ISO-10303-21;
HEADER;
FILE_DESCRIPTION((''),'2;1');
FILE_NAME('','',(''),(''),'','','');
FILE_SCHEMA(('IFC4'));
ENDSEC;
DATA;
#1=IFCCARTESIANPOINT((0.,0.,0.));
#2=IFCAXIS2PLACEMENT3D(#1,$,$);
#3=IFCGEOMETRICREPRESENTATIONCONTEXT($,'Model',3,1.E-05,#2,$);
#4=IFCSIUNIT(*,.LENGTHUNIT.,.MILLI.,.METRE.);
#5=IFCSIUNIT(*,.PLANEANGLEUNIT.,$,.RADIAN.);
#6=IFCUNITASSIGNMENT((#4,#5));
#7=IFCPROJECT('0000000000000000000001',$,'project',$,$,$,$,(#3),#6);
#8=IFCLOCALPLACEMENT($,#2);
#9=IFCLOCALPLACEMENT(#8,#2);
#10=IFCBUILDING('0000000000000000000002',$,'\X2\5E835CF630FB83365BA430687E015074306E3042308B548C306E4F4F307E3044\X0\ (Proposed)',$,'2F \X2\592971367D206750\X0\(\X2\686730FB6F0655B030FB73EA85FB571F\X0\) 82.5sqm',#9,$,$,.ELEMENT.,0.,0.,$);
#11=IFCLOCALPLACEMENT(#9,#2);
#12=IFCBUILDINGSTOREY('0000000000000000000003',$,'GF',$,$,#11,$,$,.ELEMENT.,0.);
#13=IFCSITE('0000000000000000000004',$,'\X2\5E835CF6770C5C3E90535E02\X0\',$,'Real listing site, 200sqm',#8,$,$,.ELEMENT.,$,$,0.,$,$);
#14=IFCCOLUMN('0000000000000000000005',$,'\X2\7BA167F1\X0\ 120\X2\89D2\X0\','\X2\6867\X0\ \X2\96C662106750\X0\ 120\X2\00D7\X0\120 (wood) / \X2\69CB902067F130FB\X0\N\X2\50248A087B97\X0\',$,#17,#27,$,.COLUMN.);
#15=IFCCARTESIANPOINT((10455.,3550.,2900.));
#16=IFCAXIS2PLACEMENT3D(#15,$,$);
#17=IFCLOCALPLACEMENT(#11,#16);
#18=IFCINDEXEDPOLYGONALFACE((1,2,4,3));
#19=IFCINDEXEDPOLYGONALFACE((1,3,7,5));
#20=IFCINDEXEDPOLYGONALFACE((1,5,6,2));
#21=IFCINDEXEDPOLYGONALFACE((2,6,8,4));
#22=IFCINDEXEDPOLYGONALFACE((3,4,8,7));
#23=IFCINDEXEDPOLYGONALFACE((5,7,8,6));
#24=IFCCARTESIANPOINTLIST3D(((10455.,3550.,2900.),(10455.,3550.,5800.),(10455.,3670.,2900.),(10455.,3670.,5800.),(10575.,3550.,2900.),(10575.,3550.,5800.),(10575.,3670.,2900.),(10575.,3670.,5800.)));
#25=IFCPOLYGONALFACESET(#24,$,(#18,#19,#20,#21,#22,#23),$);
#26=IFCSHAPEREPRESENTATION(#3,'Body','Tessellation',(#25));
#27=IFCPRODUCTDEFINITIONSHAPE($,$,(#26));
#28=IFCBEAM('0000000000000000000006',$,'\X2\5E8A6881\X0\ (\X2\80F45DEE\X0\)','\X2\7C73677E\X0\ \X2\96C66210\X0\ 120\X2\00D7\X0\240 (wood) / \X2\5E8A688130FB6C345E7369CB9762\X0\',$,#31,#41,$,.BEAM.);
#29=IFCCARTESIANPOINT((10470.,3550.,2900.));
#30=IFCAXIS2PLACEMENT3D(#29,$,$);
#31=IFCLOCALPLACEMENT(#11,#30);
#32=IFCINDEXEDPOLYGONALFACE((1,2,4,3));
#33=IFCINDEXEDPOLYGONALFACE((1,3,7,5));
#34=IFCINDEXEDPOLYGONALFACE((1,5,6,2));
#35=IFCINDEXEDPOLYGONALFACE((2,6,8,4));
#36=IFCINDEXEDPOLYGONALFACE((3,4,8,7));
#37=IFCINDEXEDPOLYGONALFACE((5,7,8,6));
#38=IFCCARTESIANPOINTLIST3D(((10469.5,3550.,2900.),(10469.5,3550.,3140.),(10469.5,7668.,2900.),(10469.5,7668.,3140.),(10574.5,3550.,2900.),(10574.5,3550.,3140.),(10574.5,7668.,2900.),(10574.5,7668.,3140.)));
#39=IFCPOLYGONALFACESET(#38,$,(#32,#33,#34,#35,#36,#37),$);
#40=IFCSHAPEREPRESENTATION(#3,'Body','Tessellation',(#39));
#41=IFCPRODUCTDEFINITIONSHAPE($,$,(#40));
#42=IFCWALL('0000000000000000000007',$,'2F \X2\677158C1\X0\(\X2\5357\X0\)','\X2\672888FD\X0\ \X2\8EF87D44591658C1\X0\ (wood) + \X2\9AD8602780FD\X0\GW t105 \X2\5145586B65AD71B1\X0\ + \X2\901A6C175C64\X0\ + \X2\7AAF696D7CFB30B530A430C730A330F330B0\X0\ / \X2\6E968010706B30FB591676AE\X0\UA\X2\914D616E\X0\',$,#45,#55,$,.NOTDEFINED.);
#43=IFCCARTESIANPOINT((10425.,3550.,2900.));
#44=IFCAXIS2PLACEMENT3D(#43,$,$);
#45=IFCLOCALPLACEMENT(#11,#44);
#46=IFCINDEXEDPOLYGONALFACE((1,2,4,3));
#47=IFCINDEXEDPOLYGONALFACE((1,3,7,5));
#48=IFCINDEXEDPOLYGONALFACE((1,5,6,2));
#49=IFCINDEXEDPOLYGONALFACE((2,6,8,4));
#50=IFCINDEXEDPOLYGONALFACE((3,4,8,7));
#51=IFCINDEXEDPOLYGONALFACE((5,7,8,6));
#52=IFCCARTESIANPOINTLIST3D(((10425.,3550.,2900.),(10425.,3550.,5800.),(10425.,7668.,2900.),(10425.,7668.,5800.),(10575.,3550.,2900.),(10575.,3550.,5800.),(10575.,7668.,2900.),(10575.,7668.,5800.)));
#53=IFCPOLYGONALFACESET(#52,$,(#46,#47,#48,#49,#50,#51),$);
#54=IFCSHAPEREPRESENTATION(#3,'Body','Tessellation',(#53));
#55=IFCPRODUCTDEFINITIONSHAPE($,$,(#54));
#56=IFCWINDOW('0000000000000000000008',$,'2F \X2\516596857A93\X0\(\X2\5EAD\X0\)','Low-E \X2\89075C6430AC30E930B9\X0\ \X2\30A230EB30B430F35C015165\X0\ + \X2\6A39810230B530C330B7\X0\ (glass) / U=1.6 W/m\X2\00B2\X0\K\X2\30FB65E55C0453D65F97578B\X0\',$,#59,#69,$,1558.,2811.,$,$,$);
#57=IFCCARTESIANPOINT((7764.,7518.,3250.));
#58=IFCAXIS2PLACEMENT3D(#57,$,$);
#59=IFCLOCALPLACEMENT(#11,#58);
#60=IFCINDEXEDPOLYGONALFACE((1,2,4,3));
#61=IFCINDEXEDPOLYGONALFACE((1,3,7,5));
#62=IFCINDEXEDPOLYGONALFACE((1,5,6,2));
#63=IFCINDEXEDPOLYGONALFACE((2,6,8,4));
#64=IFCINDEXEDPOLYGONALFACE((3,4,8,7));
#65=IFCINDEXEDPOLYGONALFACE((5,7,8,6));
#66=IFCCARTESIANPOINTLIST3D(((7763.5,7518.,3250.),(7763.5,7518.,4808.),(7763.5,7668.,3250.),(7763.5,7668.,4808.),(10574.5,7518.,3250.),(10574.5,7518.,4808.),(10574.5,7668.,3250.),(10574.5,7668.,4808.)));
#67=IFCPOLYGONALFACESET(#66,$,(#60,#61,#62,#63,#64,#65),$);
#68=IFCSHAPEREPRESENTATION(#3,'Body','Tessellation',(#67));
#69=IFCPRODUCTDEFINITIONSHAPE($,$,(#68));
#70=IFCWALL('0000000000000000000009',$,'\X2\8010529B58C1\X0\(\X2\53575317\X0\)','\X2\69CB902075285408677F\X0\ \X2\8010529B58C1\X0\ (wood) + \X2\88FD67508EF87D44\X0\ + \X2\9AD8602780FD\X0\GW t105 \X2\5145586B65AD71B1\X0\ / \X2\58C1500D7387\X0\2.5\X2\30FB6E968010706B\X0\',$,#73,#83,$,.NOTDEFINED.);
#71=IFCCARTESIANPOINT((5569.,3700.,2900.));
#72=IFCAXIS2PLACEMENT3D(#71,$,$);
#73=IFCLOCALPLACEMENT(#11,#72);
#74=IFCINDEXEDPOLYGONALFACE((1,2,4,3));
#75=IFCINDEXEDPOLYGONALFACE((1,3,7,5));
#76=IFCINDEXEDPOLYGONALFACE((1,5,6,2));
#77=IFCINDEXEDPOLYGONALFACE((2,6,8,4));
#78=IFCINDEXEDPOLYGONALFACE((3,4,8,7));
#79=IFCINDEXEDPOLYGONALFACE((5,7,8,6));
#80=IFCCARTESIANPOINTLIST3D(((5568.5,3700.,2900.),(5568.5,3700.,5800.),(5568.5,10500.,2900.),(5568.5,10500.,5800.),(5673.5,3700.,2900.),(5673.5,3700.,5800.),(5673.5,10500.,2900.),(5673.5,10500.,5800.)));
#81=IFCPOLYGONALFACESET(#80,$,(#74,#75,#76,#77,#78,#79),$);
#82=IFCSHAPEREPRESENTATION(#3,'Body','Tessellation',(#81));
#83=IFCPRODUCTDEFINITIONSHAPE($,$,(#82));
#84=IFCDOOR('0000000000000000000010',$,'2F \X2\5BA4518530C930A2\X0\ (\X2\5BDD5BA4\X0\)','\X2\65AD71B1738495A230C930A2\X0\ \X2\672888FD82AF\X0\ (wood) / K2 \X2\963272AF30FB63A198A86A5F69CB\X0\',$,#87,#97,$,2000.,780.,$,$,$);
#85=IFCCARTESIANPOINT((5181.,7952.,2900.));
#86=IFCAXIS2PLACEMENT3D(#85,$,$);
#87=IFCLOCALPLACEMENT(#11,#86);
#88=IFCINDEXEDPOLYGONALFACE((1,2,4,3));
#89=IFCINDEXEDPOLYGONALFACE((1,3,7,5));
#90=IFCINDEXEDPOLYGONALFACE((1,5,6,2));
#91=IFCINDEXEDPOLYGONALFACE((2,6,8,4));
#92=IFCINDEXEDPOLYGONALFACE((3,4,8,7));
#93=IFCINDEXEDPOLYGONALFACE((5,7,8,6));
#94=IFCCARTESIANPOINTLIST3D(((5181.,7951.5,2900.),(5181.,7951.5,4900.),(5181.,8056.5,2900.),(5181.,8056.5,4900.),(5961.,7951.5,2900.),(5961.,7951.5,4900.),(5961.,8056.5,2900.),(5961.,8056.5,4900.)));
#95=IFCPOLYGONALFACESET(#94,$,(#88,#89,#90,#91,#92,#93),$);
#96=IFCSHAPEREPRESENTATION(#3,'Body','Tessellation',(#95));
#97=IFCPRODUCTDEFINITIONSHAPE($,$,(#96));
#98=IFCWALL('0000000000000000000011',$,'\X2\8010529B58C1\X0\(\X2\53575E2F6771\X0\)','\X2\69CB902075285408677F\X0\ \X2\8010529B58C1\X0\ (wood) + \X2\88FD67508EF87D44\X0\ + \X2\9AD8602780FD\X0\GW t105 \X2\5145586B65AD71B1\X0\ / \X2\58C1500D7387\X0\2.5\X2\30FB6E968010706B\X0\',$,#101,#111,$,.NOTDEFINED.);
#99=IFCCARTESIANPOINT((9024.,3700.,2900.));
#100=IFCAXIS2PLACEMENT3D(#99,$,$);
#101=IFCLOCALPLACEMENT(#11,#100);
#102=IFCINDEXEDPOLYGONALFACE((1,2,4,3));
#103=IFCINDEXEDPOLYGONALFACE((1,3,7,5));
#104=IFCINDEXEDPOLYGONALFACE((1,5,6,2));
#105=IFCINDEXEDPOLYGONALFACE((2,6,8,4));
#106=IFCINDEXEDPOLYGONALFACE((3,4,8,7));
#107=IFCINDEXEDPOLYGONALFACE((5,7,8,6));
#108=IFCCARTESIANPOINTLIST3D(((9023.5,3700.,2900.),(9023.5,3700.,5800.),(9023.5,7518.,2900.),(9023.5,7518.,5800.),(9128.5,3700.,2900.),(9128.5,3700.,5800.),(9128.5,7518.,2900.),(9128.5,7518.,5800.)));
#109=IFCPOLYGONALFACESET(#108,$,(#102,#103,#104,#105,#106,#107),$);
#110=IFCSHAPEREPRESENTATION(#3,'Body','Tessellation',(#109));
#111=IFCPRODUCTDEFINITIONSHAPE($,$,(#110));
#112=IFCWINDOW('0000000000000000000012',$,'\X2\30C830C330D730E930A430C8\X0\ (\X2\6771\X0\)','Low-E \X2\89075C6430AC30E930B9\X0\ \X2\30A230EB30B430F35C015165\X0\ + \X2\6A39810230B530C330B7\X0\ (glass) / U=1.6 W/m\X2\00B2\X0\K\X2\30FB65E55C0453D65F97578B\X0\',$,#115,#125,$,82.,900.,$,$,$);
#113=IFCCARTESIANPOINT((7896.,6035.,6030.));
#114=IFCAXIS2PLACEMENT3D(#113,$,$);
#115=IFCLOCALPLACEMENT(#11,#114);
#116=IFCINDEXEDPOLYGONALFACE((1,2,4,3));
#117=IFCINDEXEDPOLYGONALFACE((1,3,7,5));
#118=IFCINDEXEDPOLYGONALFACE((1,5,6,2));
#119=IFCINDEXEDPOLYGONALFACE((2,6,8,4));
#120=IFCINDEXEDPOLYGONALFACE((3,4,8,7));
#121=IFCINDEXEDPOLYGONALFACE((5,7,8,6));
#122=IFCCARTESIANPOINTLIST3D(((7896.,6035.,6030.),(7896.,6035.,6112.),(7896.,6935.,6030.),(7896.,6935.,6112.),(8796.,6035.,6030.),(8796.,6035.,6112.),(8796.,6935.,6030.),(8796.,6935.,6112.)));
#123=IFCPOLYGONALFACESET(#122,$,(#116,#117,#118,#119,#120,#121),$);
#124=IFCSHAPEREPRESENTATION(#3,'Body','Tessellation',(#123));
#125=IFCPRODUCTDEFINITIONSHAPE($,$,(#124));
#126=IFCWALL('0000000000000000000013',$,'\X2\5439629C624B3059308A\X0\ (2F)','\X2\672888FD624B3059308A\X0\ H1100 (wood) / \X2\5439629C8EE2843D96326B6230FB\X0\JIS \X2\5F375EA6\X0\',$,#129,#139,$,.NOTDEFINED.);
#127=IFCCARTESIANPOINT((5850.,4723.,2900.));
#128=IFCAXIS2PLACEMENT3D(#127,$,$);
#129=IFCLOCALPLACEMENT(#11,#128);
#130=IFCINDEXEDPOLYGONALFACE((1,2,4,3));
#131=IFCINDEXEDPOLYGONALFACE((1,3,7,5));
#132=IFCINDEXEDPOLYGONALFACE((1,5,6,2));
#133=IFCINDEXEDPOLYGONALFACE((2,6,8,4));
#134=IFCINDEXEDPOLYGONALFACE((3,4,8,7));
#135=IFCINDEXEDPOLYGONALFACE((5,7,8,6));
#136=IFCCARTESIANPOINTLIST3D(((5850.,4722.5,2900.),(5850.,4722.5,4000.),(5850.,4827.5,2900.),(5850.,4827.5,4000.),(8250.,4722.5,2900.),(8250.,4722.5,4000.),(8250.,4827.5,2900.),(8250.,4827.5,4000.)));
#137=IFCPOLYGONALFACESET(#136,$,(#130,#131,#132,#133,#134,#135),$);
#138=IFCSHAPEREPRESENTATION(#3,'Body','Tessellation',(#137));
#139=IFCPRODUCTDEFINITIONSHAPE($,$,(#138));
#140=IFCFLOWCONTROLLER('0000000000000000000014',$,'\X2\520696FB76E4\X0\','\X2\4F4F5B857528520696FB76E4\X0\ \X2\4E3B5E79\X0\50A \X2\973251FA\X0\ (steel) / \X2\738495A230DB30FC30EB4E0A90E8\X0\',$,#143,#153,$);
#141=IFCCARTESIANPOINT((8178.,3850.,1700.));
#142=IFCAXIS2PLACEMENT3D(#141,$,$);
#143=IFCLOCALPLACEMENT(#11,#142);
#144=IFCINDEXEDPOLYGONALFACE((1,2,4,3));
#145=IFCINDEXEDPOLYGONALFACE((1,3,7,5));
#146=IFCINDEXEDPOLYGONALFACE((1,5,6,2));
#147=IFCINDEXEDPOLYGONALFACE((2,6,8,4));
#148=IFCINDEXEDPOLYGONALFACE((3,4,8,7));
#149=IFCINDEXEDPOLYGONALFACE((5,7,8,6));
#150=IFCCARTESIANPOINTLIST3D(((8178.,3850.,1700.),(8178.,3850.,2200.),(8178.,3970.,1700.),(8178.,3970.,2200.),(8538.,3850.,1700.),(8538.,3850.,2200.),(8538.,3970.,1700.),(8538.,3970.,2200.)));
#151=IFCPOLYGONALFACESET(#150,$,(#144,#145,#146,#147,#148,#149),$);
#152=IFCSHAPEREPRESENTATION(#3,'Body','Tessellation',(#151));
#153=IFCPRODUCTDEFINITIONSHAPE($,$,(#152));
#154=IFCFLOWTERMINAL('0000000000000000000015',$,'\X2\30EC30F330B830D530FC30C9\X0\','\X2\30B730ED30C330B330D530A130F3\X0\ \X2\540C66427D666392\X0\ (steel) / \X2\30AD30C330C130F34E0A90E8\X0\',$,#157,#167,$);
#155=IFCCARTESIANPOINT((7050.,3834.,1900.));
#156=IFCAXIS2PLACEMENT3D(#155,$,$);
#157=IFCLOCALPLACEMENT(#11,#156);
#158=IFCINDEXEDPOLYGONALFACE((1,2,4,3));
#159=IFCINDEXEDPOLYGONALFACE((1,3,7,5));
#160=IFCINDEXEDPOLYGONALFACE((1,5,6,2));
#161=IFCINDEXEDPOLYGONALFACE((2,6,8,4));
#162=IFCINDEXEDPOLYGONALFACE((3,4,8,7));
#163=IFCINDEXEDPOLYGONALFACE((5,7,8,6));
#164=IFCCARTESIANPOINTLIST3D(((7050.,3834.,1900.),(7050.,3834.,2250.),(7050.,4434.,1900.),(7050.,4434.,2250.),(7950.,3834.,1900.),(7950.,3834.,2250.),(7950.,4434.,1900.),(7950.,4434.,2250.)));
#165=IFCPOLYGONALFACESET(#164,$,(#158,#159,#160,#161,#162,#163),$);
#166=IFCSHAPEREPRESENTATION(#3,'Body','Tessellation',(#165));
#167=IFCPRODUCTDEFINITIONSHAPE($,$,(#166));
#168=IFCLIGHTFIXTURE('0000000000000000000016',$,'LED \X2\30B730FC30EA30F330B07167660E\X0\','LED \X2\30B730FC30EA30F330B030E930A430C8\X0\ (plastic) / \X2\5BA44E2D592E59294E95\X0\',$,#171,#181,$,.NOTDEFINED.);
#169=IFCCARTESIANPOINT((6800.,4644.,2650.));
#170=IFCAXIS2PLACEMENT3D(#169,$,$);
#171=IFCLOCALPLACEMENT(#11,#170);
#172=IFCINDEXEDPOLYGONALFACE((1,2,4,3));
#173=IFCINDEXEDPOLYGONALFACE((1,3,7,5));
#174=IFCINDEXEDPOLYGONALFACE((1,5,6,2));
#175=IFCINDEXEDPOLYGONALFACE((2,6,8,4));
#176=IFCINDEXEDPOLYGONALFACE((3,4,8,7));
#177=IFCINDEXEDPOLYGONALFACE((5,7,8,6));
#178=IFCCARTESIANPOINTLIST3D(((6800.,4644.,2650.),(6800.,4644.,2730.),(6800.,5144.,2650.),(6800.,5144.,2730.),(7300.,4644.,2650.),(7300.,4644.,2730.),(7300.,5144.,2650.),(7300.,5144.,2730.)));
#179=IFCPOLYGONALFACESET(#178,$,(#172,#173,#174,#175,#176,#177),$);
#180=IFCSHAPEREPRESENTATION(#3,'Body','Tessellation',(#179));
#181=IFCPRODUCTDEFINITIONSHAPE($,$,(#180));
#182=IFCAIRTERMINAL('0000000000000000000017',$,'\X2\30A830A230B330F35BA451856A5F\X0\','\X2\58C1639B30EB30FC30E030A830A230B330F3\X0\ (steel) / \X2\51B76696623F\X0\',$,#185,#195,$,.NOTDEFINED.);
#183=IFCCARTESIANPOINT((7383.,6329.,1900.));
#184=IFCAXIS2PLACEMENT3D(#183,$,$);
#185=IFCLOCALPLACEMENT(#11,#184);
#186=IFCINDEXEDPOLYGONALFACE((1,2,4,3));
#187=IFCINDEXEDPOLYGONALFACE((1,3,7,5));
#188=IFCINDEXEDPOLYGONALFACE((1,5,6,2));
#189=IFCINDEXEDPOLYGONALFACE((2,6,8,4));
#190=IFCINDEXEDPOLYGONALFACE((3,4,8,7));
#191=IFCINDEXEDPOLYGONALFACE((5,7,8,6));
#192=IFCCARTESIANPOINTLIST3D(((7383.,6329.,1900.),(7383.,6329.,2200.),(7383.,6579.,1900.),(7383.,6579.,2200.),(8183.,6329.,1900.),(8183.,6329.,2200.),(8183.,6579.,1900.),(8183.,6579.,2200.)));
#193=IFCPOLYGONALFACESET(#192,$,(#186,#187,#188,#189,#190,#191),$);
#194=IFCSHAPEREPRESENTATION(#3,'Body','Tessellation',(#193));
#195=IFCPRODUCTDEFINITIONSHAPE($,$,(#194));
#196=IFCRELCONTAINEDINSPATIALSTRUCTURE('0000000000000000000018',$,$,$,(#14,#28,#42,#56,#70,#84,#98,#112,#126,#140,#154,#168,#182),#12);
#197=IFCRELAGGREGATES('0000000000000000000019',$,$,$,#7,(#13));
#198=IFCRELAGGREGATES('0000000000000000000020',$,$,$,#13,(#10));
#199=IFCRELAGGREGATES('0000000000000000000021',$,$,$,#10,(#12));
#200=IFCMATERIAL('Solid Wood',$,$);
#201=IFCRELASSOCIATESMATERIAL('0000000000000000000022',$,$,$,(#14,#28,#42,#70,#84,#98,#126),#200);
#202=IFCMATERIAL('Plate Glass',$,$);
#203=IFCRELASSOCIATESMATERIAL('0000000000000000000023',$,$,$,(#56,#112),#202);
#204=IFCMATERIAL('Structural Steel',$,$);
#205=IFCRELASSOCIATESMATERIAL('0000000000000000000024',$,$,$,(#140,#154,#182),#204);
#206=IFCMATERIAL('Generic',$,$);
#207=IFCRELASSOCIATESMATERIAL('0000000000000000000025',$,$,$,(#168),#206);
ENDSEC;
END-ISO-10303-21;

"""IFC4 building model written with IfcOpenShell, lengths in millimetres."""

from ifc_helpers import new_model, si_unit, frame, frame_2d, origin, place, context, project, spatial, rectangle, extrude, material, element, fill, save


model = new_model("IFC4")

# Units and contexts
model_context = context("Model", 3, precision=1e-05, world=origin())
ifc_project = project(units=[si_unit("LENGTHUNIT", "METRE", prefix="MILLI"), si_unit("PLANEANGLEUNIT", "RADIAN")], contexts=[model_context])

# Site, building, storey
site_placement = place(None, origin())
site = spatial("IfcSite", under=ifc_project, at=site_placement, Name="広島県尾道市", ObjectType="Real listing site, 200sqm", CompositionType="ELEMENT", RefElevation=0.0)
building_placement = place(site_placement, origin())
building = spatial("IfcBuilding", under=site, at=building_placement, Name="広島・茶室と縁側のある和の住まい (Proposed)", ObjectType="2F 天然素材(桧・漆喰・珪藻土) 82.5sqm", CompositionType="ELEMENT", ElevationOfRefHeight=0.0, ElevationOfTerrain=0.0)
storey_placement = place(building_placement, origin())
storey = spatial("IfcBuildingStorey", under=building, at=storey_placement, Name="GF", CompositionType="ELEMENT", Elevation=0.0)

# Column
ifc_material_1 = material(Name="Solid Wood")
column_1_placement = place(storey_placement, frame((10455.0, 3550.0, 2900.0)))
element("IfcColumn", 1, at=column_1_placement, inside=storey, material=ifc_material_1, Name="管柱 120角", Description="桧 集成材 120×120 (wood) / 構造柱・N値計算", PredefinedType="COLUMN", context=model_context, shape_type="SweptSolid", body=[
    extrude(rectangle(XDim=120.0, YDim=120.0, at=frame_2d((60.0, 60.0))), frame((10455.0, 3550.0, 2900.0)), (0.0, 0.0, 1.0), 2900.0),
])

# Beam
beam_placement = place(storey_placement, frame((10470.0, 3550.0, 2900.0)))
element("IfcBeam", 2, at=beam_placement, inside=storey, material=ifc_material_1, Name="床梁 (胴差)", Description="米松 集成 120×240 (wood) / 床梁・水平構面", PredefinedType="BEAM", context=model_context, shape_type="SweptSolid", body=[
    extrude(rectangle(XDim=105.0, YDim=4118.0, at=frame_2d((52.0, 2059.0))), frame((10470.0, 3550.0, 2900.0)), (0.0, 0.0, 1.0), 240.0),
])

# Wall, opening, window
wall_1_placement = place(storey_placement, frame((10425.0, 3550.0, 2900.0)))
wall_1 = element("IfcWall", 3, at=wall_1_placement, inside=storey, material=ifc_material_1, Name="2F 東壁(南)", Description="木製 軸組外壁 (wood) + 高性能GW t105 充填断熱 + 通気層 + 窯業系サイディング / 準耐火・外皮UA配慮", PredefinedType="NOTDEFINED", context=model_context, shape_type="SweptSolid", body=[
    extrude(rectangle(XDim=150.0, YDim=4118.0, at=frame_2d((75.0, 2059.0))), frame((10425.0, 3550.0, 2900.0)), (0.0, 0.0, 1.0), 2900.0),
])
opening_1_placement = place(storey_placement, frame((7764.0, 7518.0, 3250.0)))
opening_1 = element("IfcOpeningElement", 4, at=opening_1_placement, cuts=wall_1, PredefinedType="NOTDEFINED", context=model_context, shape_type="SweptSolid", body=[
    extrude(rectangle(XDim=2811.0, YDim=150.0, at=frame_2d((1405.0, 75.0))), frame((7764.0, 7518.0, 3250.0)), (0.0, 0.0, 1.0), 1558.0),
])
ifc_material_2 = material(Name="Plate Glass")
window_1_placement = place(storey_placement, frame((7764.0, 7518.0, 3250.0)))
window_1 = element("IfcWindow", 5, at=window_1_placement, inside=storey, material=ifc_material_2, Name="2F 入隅窓(庭)", Description="Low-E 複層ガラス アルゴン封入 + 樹脂サッシ (glass) / U=1.6 W/m²K・日射取得型", OverallHeight=1558.0, OverallWidth=2811.0, context=model_context, shape_type="SweptSolid", body=[
    extrude(rectangle(XDim=2811.0, YDim=150.0, at=frame_2d((1405.0, 75.0))), frame((7764.0, 7518.0, 3250.0)), (0.0, 0.0, 1.0), 1558.0),
])
fill(opening_1, window_1)

# Wall, opening, door
wall_2_placement = place(storey_placement, frame((5569.0, 3700.0, 2900.0)))
wall_2 = element("IfcWall", 6, at=wall_2_placement, inside=storey, material=ifc_material_1, Name="耐力壁(南北)", Description="構造用合板 耐力壁 (wood) + 製材軸組 + 高性能GW t105 充填断熱 / 壁倍率2.5・準耐火", PredefinedType="NOTDEFINED", context=model_context, shape_type="SweptSolid", body=[
    extrude(rectangle(XDim=105.0, YDim=6800.0, at=frame_2d((52.0, 3400.0))), frame((5569.0, 3700.0, 2900.0)), (0.0, 0.0, 1.0), 2900.0),
])
opening_2_placement = place(storey_placement, frame((5181.0, 7952.0, 2900.0)))
opening_2 = element("IfcOpeningElement", 7, at=opening_2_placement, cuts=wall_2, PredefinedType="NOTDEFINED", context=model_context, shape_type="SweptSolid", body=[
    extrude(rectangle(XDim=780.0, YDim=105.0, at=frame_2d((390.0, 52.0))), frame((5181.0, 7952.0, 2900.0)), (0.0, 0.0, 1.0), 2000.0),
])
door_placement = place(storey_placement, frame((5181.0, 7952.0, 2900.0)))
door = element("IfcDoor", 8, at=door_placement, inside=storey, material=ifc_material_1, Name="2F 室内ドア (寝室)", Description="断熱玄関ドア 木製芯 (wood) / K2 防犯・採風機構", OverallHeight=2000.0, OverallWidth=780.0, context=model_context, shape_type="SweptSolid", body=[
    extrude(rectangle(XDim=780.0, YDim=105.0, at=frame_2d((390.0, 52.0))), frame((5181.0, 7952.0, 2900.0)), (0.0, 0.0, 1.0), 2000.0),
])
fill(opening_2, door)

# Wall
wall_3_placement = place(storey_placement, frame((9024.0, 3700.0, 2900.0)))
element("IfcWall", 9, at=wall_3_placement, inside=storey, material=ifc_material_1, Name="耐力壁(南帯東)", Description="構造用合板 耐力壁 (wood) + 製材軸組 + 高性能GW t105 充填断熱 / 壁倍率2.5・準耐火", PredefinedType="NOTDEFINED", context=model_context, shape_type="SweptSolid", body=[
    extrude(rectangle(XDim=105.0, YDim=3818.0, at=frame_2d((52.0, 1909.0))), frame((9024.0, 3700.0, 2900.0)), (0.0, 0.0, 1.0), 2900.0),
])

# Window
window_2_placement = place(storey_placement, frame((7896.0, 6035.0, 6030.0)))
element("IfcWindow", 10, at=window_2_placement, inside=storey, material=ifc_material_2, Name="トップライト (東)", Description="Low-E 複層ガラス アルゴン封入 + 樹脂サッシ (glass) / U=1.6 W/m²K・日射取得型", OverallHeight=82.0, OverallWidth=900.0, context=model_context, shape_type="SweptSolid", body=[
    extrude(rectangle(XDim=900.0, YDim=900.0, at=frame_2d((450.0, 450.0))), frame((7896.0, 6035.0, 6030.0)), (0.0, 0.0, 1.0), 82.0),
])

# Wall
wall_4_placement = place(storey_placement, frame((5850.0, 4723.0, 2900.0)))
element("IfcWall", 11, at=wall_4_placement, inside=storey, material=ifc_material_1, Name="吹抜手すり (2F)", Description="木製手すり H1100 (wood) / 吹抜転落防止・JIS 強度", PredefinedType="NOTDEFINED", context=model_context, shape_type="SweptSolid", body=[
    extrude(rectangle(XDim=2400.0, YDim=105.0, at=frame_2d((1200.0, 52.0))), frame((5850.0, 4723.0, 2900.0)), (0.0, 0.0, 1.0), 1100.0),
])

# Flow controller
ifc_material_3 = material(Name="Structural Steel")
flow_controller_placement = place(storey_placement, frame((8178.0, 3850.0, 1700.0)))
element("IfcFlowController", 12, at=flow_controller_placement, inside=storey, material=ifc_material_3, Name="分電盤", Description="住宅用分電盤 主幹50A 露出 (steel) / 玄関ホール上部", context=model_context, shape_type="SweptSolid", body=[
    extrude(rectangle(XDim=360.0, YDim=120.0, at=frame_2d((180.0, 60.0))), frame((8178.0, 3850.0, 1700.0)), (0.0, 0.0, 1.0), 500.0),
])

# Flow terminal
flow_terminal_placement = place(storey_placement, frame((7050.0, 3834.0, 1900.0)))
element("IfcFlowTerminal", 13, at=flow_terminal_placement, inside=storey, material=ifc_material_3, Name="レンジフード", Description="シロッコファン 同時給排 (steel) / キッチン上部", context=model_context, shape_type="SweptSolid", body=[
    extrude(rectangle(XDim=900.0, YDim=600.0, at=frame_2d((450.0, 300.0))), frame((7050.0, 3834.0, 1900.0)), (0.0, 0.0, 1.0), 350.0),
])

# Light fixture
ifc_material_4 = material(Name="Generic")
light_fixture_1_placement = place(storey_placement, frame((6800.0, 4644.0, 2650.0)))
element("IfcLightFixture", 14, at=light_fixture_1_placement, inside=storey, material=ifc_material_4, Name="LED シーリング照明", Description="LED シーリングライト (plastic) / 室中央天井", PredefinedType="NOTDEFINED", context=model_context, shape_type="SweptSolid", body=[
    extrude(rectangle(XDim=500.0, YDim=500.0, at=frame_2d((250.0, 250.0))), frame((6800.0, 4644.0, 2650.0)), (0.0, 0.0, 1.0), 80.0),
])

# Air terminal
air_terminal_1_placement = place(storey_placement, frame((7383.0, 6329.0, 1900.0)))
element("IfcAirTerminal", 15, at=air_terminal_1_placement, inside=storey, material=ifc_material_3, Name="エアコン室内機", Description="壁掛ルームエアコン (steel) / 冷暖房", PredefinedType="NOTDEFINED", context=model_context, shape_type="SweptSolid", body=[
    extrude(rectangle(XDim=800.0, YDim=250.0, at=frame_2d((400.0, 125.0))), frame((7383.0, 6329.0, 1900.0)), (0.0, 0.0, 1.0), 300.0),
])

save(model, "model.ifc")
